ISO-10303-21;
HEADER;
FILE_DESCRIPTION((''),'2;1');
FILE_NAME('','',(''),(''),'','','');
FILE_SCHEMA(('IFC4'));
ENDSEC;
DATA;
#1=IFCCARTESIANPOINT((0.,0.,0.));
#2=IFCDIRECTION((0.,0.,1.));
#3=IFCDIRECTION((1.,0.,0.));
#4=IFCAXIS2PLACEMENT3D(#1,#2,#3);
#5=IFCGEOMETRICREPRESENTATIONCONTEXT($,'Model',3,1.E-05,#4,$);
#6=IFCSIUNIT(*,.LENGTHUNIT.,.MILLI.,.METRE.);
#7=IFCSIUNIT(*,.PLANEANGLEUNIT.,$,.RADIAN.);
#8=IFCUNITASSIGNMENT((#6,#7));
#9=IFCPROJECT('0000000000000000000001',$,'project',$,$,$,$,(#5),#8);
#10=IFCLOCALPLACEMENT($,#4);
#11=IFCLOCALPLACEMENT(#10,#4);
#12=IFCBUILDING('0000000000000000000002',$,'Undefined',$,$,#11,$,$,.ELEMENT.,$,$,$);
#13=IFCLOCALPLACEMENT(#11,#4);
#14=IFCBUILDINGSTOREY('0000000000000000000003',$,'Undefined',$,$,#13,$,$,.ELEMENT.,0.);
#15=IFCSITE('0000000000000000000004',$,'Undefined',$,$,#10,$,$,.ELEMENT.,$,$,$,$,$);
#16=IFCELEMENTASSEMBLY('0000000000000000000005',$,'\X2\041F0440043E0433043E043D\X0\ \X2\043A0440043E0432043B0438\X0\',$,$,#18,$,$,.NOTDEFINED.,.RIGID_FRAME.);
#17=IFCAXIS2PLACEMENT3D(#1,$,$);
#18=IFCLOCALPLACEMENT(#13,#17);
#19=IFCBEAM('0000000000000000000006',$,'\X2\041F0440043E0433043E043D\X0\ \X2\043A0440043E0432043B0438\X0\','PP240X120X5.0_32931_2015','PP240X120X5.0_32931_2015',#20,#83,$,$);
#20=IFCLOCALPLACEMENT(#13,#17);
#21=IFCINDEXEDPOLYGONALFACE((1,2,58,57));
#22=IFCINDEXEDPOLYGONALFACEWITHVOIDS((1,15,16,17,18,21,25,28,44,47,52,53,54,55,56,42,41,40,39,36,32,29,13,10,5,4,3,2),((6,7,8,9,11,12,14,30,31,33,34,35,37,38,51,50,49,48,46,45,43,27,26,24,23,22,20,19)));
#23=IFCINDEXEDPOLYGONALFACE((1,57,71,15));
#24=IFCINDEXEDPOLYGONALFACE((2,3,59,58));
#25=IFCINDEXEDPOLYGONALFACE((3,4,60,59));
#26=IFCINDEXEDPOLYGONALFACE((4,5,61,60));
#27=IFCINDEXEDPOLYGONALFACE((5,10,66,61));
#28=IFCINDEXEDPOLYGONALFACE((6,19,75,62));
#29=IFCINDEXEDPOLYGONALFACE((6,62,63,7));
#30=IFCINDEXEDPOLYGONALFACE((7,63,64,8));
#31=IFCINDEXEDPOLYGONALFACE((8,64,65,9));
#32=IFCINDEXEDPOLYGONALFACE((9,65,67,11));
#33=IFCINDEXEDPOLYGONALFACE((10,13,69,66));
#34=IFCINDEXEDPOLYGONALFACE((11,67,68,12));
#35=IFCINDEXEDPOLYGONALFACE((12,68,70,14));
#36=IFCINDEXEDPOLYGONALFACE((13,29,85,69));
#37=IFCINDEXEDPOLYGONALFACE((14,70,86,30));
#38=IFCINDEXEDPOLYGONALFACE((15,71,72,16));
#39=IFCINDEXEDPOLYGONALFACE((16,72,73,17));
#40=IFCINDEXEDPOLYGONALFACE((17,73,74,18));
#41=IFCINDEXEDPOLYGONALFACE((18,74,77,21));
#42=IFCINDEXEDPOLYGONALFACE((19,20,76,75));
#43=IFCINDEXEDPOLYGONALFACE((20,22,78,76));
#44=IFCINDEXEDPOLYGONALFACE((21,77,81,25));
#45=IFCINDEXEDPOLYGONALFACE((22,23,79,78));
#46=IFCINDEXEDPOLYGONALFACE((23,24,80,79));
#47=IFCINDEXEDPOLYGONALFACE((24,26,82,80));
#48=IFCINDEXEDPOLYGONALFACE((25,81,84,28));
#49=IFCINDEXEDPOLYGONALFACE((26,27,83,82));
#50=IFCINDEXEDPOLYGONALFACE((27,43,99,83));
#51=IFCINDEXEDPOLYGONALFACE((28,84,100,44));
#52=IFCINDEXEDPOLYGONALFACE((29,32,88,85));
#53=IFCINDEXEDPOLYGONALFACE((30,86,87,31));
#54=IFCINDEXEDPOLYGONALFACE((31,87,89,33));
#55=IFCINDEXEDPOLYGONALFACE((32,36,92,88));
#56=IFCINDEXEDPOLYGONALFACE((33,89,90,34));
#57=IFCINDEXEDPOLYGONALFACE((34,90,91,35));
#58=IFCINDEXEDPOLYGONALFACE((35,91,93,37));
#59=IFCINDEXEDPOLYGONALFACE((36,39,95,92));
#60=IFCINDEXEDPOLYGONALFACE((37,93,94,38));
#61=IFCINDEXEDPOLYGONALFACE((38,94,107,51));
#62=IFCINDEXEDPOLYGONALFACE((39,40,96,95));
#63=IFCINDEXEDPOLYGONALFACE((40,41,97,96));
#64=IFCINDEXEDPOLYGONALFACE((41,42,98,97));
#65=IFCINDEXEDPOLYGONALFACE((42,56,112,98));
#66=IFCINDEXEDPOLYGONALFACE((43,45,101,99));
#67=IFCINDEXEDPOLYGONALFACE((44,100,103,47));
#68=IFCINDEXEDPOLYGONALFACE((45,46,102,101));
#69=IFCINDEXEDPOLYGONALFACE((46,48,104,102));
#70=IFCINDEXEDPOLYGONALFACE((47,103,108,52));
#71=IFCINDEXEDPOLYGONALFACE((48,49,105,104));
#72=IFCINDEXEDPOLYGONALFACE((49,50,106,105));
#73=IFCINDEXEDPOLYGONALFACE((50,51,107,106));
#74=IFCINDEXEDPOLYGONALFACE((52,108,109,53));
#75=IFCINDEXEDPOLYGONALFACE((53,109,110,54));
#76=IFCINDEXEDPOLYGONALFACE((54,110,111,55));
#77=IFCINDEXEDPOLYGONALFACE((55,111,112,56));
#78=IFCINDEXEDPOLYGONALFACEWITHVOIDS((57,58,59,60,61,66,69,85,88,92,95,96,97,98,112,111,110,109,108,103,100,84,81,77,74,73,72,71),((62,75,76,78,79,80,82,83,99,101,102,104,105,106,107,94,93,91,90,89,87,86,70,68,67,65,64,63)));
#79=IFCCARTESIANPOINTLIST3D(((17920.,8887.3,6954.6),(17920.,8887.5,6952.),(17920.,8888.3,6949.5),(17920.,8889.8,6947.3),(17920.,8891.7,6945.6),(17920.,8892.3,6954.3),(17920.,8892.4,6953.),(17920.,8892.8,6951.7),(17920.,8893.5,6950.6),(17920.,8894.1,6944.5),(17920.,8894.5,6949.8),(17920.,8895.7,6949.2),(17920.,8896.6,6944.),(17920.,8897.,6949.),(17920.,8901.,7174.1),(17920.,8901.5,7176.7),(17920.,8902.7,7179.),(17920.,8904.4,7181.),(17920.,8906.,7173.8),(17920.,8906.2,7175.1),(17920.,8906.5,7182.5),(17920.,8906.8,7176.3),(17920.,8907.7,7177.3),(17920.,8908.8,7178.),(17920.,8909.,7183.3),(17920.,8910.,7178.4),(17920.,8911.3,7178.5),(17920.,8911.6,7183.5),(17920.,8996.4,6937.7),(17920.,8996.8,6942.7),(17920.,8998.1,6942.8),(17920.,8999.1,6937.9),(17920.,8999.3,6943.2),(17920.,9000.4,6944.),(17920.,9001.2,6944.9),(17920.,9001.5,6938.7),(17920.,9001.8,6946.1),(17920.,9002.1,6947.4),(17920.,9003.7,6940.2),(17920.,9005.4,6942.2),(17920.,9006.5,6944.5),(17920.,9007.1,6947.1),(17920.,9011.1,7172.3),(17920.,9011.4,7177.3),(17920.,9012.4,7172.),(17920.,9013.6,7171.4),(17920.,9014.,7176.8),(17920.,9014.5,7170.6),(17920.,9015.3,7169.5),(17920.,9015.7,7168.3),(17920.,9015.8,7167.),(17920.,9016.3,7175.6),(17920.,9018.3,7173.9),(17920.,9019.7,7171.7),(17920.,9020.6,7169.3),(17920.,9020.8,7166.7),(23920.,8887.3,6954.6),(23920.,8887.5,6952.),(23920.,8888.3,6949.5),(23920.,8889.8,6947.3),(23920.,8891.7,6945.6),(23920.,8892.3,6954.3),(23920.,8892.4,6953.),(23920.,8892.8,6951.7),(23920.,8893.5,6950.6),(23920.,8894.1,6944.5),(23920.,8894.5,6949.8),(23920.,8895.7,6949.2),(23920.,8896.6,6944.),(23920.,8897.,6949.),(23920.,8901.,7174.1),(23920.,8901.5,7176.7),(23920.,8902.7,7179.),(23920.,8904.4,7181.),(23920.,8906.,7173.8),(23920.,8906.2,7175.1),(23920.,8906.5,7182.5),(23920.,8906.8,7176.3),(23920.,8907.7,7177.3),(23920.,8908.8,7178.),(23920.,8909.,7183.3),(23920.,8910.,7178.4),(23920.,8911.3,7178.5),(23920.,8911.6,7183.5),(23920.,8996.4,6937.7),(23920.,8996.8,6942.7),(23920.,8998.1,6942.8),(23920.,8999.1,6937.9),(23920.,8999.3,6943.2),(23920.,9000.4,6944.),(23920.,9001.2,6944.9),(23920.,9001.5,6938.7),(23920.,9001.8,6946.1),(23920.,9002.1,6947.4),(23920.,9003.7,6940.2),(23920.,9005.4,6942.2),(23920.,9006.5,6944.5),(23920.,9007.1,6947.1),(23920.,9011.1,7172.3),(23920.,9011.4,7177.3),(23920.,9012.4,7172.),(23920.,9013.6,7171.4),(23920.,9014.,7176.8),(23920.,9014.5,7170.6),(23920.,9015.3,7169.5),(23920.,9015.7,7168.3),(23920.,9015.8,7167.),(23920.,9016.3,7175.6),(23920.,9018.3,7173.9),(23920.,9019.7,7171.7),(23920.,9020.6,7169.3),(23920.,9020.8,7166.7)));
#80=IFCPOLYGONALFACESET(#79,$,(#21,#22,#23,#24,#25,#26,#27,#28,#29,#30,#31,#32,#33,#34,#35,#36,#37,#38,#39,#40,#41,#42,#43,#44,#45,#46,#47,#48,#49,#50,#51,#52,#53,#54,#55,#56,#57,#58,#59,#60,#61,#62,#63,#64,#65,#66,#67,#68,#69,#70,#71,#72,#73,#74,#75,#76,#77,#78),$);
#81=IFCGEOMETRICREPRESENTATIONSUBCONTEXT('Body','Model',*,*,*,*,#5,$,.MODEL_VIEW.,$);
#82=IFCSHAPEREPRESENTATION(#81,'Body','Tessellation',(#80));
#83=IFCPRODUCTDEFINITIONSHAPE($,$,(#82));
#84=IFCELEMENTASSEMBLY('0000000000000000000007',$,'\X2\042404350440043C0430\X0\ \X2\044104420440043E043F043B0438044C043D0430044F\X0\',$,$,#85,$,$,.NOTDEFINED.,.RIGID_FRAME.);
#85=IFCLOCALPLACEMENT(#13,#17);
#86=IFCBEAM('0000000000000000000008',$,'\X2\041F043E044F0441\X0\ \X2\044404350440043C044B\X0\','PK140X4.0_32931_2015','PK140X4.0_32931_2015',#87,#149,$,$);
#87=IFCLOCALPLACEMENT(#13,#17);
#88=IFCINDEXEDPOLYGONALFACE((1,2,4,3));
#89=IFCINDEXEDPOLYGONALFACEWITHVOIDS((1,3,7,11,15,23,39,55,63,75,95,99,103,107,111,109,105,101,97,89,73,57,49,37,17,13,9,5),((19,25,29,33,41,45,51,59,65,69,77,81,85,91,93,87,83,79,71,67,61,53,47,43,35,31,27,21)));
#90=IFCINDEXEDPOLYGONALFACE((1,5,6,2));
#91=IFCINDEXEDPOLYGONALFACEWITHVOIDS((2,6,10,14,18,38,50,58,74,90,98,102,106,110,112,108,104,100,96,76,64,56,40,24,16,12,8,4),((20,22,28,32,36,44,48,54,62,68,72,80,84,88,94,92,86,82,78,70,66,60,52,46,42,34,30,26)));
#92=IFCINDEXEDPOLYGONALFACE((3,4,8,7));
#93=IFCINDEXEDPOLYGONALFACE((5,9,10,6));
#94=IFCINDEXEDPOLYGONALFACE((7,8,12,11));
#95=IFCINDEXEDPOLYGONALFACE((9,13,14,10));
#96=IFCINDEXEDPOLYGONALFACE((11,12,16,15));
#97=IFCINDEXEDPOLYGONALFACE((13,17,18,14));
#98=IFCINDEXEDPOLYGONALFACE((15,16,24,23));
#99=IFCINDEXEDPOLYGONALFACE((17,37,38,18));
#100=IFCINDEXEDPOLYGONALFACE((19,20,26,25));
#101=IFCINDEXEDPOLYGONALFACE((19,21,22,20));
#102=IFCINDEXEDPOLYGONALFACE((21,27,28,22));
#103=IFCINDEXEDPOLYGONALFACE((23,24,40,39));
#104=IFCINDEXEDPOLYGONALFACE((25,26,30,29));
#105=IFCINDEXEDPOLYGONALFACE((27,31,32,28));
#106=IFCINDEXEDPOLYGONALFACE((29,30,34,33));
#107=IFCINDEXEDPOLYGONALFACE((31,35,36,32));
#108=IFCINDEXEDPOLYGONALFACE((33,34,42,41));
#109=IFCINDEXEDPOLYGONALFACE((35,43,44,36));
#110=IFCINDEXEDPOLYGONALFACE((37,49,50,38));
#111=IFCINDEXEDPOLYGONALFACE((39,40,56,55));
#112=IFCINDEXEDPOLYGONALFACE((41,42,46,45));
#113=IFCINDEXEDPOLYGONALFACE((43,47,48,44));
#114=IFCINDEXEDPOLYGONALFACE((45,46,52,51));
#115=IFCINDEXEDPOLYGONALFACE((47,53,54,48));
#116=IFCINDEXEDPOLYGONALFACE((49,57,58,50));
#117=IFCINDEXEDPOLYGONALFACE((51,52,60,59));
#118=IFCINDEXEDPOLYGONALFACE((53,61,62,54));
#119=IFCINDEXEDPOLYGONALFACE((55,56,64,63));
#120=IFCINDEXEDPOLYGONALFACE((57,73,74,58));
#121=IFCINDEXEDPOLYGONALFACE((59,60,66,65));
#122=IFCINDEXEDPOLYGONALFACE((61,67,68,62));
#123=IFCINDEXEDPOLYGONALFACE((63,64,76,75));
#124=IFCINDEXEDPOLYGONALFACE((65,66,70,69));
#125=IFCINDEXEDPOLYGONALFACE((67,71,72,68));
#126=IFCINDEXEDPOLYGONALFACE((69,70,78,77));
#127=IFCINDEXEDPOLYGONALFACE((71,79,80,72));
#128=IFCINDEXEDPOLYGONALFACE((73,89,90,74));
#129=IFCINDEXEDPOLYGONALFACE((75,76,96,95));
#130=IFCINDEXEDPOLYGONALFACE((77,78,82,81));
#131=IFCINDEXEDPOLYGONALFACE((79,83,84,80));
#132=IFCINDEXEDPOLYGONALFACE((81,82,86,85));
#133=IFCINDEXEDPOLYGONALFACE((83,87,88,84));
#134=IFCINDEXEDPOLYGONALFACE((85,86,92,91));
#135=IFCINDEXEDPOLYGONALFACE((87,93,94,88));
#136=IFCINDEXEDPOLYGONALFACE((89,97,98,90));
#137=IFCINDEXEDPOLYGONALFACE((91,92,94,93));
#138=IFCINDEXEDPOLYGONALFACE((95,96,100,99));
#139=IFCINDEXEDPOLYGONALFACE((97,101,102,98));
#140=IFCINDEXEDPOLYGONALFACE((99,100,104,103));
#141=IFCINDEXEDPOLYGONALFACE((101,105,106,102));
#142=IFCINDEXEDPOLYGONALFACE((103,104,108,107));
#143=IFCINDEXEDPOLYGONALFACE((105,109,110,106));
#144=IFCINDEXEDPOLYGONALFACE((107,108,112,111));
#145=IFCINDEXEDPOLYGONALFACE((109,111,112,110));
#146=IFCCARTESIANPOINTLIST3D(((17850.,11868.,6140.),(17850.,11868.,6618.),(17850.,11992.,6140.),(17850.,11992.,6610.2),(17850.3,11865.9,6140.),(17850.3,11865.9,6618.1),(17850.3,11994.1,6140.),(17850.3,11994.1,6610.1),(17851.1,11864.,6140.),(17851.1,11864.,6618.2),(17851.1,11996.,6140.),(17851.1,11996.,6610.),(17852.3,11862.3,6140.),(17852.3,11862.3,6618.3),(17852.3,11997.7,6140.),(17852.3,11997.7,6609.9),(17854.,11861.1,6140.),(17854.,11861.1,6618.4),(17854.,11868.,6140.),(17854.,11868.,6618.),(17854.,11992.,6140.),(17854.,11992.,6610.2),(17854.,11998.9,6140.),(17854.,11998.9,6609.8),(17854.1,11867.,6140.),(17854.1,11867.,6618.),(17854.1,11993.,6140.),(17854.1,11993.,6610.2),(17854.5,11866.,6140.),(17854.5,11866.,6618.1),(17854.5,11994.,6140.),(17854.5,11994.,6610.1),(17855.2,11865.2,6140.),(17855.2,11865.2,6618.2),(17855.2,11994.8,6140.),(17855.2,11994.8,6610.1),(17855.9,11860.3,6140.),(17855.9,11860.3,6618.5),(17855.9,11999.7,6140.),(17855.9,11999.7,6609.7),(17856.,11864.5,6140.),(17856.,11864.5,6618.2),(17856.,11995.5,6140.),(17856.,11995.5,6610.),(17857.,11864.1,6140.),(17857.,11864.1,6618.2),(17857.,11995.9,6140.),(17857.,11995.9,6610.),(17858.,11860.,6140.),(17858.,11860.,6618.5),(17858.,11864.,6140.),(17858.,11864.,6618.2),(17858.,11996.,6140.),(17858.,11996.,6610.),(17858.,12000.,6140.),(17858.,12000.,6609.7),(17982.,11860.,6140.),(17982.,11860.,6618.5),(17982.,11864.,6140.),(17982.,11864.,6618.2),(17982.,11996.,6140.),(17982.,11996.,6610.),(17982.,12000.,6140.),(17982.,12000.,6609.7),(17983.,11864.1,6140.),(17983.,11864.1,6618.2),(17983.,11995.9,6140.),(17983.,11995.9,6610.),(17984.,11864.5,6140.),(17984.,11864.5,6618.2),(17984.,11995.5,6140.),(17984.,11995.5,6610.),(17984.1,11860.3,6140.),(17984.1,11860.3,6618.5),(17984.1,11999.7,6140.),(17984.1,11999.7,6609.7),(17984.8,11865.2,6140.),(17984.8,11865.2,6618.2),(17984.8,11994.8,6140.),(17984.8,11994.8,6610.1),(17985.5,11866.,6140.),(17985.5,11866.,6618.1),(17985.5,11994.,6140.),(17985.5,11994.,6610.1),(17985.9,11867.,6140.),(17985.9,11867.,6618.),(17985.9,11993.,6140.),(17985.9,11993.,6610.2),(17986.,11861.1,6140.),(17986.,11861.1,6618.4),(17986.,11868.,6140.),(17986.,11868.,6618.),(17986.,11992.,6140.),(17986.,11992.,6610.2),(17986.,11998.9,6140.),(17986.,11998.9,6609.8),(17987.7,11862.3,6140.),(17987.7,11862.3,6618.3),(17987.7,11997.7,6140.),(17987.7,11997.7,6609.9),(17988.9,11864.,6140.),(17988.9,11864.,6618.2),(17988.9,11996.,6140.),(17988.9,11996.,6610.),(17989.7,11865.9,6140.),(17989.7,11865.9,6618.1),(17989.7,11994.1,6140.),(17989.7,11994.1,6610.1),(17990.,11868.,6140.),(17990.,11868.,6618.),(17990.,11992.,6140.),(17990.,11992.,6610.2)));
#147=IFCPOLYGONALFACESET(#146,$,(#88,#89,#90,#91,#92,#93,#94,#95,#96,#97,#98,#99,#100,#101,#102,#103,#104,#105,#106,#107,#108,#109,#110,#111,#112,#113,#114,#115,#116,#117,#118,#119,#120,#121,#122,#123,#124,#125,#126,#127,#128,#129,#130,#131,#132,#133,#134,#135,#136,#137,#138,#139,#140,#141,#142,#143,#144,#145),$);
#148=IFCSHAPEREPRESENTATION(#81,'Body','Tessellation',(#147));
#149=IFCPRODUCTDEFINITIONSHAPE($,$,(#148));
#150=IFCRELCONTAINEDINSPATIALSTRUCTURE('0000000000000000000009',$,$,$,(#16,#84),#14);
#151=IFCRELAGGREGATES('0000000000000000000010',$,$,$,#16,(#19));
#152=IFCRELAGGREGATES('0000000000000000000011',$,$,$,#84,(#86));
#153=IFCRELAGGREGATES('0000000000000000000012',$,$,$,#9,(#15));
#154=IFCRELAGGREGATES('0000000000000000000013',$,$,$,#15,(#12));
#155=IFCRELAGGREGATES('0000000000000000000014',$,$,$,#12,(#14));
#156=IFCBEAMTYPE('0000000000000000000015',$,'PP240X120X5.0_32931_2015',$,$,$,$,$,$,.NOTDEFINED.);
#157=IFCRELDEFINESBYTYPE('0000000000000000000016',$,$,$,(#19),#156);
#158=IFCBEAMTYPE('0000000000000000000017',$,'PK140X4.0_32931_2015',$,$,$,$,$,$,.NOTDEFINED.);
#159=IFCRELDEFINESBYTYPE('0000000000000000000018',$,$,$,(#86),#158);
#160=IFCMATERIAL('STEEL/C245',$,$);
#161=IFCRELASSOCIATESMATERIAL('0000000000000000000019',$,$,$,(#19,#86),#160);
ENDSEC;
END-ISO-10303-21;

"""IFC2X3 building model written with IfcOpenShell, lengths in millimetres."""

from ifc_helpers import new_model, si_unit, frame, origin_with_axes, origin_2d_with_axis, place, context, subcontext, project, spatial, hollow_rectangle, extrude, clip, halfspace, material, type_object, element, aggregate, save


model = new_model("IFC2X3")

# Units and contexts
model_context = context("Model", 3, precision=1e-05, world=origin_with_axes())
body_context = subcontext(model_context, "Body", "Model", "MODEL_VIEW")
ifc_project = project(units=[si_unit("LENGTHUNIT", "METRE", prefix="MILLI"), si_unit("PLANEANGLEUNIT", "RADIAN")], contexts=[model_context])

# Site, building, storey
site_placement = place(None, origin_with_axes())
site = spatial("IfcSite", under=ifc_project, at=site_placement, Name="Undefined", CompositionType="ELEMENT")
building_placement = place(site_placement, origin_with_axes())
building = spatial("IfcBuilding", under=site, at=building_placement, Name="Undefined", CompositionType="ELEMENT")
storey_placement = place(building_placement, origin_with_axes())
storey = spatial("IfcBuildingStorey", under=building, at=storey_placement, Name="Undefined", CompositionType="ELEMENT", Elevation=0.0)

# Shared definitions
ifc_material = material(Name="STEEL/C245")

# Element assembly, beam
beam_type_1 = type_object("IfcBeamType", Name="PP240X120X5.0_32931_2015", PredefinedType="NOTDEFINED")
assembly_1_placement = place(storey_placement, origin_with_axes())
assembly_1 = element("IfcElementAssembly", 1, at=assembly_1_placement, inside=storey, Name="Прогон кровли", AssemblyPlace="NOTDEFINED", PredefinedType="RIGID_FRAME")
beam_1_placement = place(assembly_1_placement, frame((23920.0, 8954.0, 7060.6), z_axis=(0.0, 0.062378, 0.998053), x_axis=(-1.0, 0.0, 0.0)))
beam_1 = element("IfcBeam", 2, at=beam_1_placement, type_object=beam_type_1, material=ifc_material, Name="Прогон кровли", Description="PP240X120X5.0_32931_2015", ObjectType="PP240X120X5.0_32931_2015", context=body_context, shape_type="SweptSolid", body=[
    extrude(hollow_rectangle(XDim=120.0, YDim=240.0, WallThickness=5.0, InnerFilletRadius=5.0, OuterFilletRadius=10.0, at=origin_2d_with_axis()), frame((6000.0, 0.0, 0.0), z_axis=(-1.0, 0.0, 0.0), x_axis=(0.0, -1.0, 0.0)), (0.0, 0.0, 1.0), 6000.0),
])
aggregate(assembly_1, [beam_1])

# Element assembly, beam
assembly_2_placement = place(storey_placement, origin_with_axes())
assembly_2 = element("IfcElementAssembly", 3, at=assembly_2_placement, inside=storey, Name="Ферма строплиьная", AssemblyPlace="NOTDEFINED", PredefinedType="RIGID_FRAME")
beam_type_2 = type_object("IfcBeamType", Name="PK140X4.0_32931_2015", PredefinedType="NOTDEFINED")
beam_2_placement = place(assembly_2_placement, frame((17920.0, 11930.0, 6609.7), z_axis=(1.0, 0.0, 0.0), x_axis=(0.0, 0.0, -1.0)))
beam_2 = element("IfcBeam", 4, at=beam_2_placement, type_object=beam_type_2, material=ifc_material, Name="Пояс фермы", Description="PK140X4.0_32931_2015", ObjectType="PK140X4.0_32931_2015", context=body_context, shape_type="Clipping", body=[
    clip(extrude(hollow_rectangle(XDim=140.0, YDim=140.0, WallThickness=4.0, InnerFilletRadius=4.0, OuterFilletRadius=8.0, at=origin_2d_with_axis()), frame((469.7, 0.0, 0.0), z_axis=(-1.0, 0.0, 0.0), x_axis=(0.0, -1.0, 0.0)), (0.0, 0.0, 1.0), 478.5), halfspace(frame((-14.9, -167.6, 0.0), z_axis=(-0.998053, 0.062378, 0.0), x_axis=(0.0, 0.0, 1.0)), False)),
])
aggregate(assembly_2, [beam_2])

save(model, "model.ifc")
